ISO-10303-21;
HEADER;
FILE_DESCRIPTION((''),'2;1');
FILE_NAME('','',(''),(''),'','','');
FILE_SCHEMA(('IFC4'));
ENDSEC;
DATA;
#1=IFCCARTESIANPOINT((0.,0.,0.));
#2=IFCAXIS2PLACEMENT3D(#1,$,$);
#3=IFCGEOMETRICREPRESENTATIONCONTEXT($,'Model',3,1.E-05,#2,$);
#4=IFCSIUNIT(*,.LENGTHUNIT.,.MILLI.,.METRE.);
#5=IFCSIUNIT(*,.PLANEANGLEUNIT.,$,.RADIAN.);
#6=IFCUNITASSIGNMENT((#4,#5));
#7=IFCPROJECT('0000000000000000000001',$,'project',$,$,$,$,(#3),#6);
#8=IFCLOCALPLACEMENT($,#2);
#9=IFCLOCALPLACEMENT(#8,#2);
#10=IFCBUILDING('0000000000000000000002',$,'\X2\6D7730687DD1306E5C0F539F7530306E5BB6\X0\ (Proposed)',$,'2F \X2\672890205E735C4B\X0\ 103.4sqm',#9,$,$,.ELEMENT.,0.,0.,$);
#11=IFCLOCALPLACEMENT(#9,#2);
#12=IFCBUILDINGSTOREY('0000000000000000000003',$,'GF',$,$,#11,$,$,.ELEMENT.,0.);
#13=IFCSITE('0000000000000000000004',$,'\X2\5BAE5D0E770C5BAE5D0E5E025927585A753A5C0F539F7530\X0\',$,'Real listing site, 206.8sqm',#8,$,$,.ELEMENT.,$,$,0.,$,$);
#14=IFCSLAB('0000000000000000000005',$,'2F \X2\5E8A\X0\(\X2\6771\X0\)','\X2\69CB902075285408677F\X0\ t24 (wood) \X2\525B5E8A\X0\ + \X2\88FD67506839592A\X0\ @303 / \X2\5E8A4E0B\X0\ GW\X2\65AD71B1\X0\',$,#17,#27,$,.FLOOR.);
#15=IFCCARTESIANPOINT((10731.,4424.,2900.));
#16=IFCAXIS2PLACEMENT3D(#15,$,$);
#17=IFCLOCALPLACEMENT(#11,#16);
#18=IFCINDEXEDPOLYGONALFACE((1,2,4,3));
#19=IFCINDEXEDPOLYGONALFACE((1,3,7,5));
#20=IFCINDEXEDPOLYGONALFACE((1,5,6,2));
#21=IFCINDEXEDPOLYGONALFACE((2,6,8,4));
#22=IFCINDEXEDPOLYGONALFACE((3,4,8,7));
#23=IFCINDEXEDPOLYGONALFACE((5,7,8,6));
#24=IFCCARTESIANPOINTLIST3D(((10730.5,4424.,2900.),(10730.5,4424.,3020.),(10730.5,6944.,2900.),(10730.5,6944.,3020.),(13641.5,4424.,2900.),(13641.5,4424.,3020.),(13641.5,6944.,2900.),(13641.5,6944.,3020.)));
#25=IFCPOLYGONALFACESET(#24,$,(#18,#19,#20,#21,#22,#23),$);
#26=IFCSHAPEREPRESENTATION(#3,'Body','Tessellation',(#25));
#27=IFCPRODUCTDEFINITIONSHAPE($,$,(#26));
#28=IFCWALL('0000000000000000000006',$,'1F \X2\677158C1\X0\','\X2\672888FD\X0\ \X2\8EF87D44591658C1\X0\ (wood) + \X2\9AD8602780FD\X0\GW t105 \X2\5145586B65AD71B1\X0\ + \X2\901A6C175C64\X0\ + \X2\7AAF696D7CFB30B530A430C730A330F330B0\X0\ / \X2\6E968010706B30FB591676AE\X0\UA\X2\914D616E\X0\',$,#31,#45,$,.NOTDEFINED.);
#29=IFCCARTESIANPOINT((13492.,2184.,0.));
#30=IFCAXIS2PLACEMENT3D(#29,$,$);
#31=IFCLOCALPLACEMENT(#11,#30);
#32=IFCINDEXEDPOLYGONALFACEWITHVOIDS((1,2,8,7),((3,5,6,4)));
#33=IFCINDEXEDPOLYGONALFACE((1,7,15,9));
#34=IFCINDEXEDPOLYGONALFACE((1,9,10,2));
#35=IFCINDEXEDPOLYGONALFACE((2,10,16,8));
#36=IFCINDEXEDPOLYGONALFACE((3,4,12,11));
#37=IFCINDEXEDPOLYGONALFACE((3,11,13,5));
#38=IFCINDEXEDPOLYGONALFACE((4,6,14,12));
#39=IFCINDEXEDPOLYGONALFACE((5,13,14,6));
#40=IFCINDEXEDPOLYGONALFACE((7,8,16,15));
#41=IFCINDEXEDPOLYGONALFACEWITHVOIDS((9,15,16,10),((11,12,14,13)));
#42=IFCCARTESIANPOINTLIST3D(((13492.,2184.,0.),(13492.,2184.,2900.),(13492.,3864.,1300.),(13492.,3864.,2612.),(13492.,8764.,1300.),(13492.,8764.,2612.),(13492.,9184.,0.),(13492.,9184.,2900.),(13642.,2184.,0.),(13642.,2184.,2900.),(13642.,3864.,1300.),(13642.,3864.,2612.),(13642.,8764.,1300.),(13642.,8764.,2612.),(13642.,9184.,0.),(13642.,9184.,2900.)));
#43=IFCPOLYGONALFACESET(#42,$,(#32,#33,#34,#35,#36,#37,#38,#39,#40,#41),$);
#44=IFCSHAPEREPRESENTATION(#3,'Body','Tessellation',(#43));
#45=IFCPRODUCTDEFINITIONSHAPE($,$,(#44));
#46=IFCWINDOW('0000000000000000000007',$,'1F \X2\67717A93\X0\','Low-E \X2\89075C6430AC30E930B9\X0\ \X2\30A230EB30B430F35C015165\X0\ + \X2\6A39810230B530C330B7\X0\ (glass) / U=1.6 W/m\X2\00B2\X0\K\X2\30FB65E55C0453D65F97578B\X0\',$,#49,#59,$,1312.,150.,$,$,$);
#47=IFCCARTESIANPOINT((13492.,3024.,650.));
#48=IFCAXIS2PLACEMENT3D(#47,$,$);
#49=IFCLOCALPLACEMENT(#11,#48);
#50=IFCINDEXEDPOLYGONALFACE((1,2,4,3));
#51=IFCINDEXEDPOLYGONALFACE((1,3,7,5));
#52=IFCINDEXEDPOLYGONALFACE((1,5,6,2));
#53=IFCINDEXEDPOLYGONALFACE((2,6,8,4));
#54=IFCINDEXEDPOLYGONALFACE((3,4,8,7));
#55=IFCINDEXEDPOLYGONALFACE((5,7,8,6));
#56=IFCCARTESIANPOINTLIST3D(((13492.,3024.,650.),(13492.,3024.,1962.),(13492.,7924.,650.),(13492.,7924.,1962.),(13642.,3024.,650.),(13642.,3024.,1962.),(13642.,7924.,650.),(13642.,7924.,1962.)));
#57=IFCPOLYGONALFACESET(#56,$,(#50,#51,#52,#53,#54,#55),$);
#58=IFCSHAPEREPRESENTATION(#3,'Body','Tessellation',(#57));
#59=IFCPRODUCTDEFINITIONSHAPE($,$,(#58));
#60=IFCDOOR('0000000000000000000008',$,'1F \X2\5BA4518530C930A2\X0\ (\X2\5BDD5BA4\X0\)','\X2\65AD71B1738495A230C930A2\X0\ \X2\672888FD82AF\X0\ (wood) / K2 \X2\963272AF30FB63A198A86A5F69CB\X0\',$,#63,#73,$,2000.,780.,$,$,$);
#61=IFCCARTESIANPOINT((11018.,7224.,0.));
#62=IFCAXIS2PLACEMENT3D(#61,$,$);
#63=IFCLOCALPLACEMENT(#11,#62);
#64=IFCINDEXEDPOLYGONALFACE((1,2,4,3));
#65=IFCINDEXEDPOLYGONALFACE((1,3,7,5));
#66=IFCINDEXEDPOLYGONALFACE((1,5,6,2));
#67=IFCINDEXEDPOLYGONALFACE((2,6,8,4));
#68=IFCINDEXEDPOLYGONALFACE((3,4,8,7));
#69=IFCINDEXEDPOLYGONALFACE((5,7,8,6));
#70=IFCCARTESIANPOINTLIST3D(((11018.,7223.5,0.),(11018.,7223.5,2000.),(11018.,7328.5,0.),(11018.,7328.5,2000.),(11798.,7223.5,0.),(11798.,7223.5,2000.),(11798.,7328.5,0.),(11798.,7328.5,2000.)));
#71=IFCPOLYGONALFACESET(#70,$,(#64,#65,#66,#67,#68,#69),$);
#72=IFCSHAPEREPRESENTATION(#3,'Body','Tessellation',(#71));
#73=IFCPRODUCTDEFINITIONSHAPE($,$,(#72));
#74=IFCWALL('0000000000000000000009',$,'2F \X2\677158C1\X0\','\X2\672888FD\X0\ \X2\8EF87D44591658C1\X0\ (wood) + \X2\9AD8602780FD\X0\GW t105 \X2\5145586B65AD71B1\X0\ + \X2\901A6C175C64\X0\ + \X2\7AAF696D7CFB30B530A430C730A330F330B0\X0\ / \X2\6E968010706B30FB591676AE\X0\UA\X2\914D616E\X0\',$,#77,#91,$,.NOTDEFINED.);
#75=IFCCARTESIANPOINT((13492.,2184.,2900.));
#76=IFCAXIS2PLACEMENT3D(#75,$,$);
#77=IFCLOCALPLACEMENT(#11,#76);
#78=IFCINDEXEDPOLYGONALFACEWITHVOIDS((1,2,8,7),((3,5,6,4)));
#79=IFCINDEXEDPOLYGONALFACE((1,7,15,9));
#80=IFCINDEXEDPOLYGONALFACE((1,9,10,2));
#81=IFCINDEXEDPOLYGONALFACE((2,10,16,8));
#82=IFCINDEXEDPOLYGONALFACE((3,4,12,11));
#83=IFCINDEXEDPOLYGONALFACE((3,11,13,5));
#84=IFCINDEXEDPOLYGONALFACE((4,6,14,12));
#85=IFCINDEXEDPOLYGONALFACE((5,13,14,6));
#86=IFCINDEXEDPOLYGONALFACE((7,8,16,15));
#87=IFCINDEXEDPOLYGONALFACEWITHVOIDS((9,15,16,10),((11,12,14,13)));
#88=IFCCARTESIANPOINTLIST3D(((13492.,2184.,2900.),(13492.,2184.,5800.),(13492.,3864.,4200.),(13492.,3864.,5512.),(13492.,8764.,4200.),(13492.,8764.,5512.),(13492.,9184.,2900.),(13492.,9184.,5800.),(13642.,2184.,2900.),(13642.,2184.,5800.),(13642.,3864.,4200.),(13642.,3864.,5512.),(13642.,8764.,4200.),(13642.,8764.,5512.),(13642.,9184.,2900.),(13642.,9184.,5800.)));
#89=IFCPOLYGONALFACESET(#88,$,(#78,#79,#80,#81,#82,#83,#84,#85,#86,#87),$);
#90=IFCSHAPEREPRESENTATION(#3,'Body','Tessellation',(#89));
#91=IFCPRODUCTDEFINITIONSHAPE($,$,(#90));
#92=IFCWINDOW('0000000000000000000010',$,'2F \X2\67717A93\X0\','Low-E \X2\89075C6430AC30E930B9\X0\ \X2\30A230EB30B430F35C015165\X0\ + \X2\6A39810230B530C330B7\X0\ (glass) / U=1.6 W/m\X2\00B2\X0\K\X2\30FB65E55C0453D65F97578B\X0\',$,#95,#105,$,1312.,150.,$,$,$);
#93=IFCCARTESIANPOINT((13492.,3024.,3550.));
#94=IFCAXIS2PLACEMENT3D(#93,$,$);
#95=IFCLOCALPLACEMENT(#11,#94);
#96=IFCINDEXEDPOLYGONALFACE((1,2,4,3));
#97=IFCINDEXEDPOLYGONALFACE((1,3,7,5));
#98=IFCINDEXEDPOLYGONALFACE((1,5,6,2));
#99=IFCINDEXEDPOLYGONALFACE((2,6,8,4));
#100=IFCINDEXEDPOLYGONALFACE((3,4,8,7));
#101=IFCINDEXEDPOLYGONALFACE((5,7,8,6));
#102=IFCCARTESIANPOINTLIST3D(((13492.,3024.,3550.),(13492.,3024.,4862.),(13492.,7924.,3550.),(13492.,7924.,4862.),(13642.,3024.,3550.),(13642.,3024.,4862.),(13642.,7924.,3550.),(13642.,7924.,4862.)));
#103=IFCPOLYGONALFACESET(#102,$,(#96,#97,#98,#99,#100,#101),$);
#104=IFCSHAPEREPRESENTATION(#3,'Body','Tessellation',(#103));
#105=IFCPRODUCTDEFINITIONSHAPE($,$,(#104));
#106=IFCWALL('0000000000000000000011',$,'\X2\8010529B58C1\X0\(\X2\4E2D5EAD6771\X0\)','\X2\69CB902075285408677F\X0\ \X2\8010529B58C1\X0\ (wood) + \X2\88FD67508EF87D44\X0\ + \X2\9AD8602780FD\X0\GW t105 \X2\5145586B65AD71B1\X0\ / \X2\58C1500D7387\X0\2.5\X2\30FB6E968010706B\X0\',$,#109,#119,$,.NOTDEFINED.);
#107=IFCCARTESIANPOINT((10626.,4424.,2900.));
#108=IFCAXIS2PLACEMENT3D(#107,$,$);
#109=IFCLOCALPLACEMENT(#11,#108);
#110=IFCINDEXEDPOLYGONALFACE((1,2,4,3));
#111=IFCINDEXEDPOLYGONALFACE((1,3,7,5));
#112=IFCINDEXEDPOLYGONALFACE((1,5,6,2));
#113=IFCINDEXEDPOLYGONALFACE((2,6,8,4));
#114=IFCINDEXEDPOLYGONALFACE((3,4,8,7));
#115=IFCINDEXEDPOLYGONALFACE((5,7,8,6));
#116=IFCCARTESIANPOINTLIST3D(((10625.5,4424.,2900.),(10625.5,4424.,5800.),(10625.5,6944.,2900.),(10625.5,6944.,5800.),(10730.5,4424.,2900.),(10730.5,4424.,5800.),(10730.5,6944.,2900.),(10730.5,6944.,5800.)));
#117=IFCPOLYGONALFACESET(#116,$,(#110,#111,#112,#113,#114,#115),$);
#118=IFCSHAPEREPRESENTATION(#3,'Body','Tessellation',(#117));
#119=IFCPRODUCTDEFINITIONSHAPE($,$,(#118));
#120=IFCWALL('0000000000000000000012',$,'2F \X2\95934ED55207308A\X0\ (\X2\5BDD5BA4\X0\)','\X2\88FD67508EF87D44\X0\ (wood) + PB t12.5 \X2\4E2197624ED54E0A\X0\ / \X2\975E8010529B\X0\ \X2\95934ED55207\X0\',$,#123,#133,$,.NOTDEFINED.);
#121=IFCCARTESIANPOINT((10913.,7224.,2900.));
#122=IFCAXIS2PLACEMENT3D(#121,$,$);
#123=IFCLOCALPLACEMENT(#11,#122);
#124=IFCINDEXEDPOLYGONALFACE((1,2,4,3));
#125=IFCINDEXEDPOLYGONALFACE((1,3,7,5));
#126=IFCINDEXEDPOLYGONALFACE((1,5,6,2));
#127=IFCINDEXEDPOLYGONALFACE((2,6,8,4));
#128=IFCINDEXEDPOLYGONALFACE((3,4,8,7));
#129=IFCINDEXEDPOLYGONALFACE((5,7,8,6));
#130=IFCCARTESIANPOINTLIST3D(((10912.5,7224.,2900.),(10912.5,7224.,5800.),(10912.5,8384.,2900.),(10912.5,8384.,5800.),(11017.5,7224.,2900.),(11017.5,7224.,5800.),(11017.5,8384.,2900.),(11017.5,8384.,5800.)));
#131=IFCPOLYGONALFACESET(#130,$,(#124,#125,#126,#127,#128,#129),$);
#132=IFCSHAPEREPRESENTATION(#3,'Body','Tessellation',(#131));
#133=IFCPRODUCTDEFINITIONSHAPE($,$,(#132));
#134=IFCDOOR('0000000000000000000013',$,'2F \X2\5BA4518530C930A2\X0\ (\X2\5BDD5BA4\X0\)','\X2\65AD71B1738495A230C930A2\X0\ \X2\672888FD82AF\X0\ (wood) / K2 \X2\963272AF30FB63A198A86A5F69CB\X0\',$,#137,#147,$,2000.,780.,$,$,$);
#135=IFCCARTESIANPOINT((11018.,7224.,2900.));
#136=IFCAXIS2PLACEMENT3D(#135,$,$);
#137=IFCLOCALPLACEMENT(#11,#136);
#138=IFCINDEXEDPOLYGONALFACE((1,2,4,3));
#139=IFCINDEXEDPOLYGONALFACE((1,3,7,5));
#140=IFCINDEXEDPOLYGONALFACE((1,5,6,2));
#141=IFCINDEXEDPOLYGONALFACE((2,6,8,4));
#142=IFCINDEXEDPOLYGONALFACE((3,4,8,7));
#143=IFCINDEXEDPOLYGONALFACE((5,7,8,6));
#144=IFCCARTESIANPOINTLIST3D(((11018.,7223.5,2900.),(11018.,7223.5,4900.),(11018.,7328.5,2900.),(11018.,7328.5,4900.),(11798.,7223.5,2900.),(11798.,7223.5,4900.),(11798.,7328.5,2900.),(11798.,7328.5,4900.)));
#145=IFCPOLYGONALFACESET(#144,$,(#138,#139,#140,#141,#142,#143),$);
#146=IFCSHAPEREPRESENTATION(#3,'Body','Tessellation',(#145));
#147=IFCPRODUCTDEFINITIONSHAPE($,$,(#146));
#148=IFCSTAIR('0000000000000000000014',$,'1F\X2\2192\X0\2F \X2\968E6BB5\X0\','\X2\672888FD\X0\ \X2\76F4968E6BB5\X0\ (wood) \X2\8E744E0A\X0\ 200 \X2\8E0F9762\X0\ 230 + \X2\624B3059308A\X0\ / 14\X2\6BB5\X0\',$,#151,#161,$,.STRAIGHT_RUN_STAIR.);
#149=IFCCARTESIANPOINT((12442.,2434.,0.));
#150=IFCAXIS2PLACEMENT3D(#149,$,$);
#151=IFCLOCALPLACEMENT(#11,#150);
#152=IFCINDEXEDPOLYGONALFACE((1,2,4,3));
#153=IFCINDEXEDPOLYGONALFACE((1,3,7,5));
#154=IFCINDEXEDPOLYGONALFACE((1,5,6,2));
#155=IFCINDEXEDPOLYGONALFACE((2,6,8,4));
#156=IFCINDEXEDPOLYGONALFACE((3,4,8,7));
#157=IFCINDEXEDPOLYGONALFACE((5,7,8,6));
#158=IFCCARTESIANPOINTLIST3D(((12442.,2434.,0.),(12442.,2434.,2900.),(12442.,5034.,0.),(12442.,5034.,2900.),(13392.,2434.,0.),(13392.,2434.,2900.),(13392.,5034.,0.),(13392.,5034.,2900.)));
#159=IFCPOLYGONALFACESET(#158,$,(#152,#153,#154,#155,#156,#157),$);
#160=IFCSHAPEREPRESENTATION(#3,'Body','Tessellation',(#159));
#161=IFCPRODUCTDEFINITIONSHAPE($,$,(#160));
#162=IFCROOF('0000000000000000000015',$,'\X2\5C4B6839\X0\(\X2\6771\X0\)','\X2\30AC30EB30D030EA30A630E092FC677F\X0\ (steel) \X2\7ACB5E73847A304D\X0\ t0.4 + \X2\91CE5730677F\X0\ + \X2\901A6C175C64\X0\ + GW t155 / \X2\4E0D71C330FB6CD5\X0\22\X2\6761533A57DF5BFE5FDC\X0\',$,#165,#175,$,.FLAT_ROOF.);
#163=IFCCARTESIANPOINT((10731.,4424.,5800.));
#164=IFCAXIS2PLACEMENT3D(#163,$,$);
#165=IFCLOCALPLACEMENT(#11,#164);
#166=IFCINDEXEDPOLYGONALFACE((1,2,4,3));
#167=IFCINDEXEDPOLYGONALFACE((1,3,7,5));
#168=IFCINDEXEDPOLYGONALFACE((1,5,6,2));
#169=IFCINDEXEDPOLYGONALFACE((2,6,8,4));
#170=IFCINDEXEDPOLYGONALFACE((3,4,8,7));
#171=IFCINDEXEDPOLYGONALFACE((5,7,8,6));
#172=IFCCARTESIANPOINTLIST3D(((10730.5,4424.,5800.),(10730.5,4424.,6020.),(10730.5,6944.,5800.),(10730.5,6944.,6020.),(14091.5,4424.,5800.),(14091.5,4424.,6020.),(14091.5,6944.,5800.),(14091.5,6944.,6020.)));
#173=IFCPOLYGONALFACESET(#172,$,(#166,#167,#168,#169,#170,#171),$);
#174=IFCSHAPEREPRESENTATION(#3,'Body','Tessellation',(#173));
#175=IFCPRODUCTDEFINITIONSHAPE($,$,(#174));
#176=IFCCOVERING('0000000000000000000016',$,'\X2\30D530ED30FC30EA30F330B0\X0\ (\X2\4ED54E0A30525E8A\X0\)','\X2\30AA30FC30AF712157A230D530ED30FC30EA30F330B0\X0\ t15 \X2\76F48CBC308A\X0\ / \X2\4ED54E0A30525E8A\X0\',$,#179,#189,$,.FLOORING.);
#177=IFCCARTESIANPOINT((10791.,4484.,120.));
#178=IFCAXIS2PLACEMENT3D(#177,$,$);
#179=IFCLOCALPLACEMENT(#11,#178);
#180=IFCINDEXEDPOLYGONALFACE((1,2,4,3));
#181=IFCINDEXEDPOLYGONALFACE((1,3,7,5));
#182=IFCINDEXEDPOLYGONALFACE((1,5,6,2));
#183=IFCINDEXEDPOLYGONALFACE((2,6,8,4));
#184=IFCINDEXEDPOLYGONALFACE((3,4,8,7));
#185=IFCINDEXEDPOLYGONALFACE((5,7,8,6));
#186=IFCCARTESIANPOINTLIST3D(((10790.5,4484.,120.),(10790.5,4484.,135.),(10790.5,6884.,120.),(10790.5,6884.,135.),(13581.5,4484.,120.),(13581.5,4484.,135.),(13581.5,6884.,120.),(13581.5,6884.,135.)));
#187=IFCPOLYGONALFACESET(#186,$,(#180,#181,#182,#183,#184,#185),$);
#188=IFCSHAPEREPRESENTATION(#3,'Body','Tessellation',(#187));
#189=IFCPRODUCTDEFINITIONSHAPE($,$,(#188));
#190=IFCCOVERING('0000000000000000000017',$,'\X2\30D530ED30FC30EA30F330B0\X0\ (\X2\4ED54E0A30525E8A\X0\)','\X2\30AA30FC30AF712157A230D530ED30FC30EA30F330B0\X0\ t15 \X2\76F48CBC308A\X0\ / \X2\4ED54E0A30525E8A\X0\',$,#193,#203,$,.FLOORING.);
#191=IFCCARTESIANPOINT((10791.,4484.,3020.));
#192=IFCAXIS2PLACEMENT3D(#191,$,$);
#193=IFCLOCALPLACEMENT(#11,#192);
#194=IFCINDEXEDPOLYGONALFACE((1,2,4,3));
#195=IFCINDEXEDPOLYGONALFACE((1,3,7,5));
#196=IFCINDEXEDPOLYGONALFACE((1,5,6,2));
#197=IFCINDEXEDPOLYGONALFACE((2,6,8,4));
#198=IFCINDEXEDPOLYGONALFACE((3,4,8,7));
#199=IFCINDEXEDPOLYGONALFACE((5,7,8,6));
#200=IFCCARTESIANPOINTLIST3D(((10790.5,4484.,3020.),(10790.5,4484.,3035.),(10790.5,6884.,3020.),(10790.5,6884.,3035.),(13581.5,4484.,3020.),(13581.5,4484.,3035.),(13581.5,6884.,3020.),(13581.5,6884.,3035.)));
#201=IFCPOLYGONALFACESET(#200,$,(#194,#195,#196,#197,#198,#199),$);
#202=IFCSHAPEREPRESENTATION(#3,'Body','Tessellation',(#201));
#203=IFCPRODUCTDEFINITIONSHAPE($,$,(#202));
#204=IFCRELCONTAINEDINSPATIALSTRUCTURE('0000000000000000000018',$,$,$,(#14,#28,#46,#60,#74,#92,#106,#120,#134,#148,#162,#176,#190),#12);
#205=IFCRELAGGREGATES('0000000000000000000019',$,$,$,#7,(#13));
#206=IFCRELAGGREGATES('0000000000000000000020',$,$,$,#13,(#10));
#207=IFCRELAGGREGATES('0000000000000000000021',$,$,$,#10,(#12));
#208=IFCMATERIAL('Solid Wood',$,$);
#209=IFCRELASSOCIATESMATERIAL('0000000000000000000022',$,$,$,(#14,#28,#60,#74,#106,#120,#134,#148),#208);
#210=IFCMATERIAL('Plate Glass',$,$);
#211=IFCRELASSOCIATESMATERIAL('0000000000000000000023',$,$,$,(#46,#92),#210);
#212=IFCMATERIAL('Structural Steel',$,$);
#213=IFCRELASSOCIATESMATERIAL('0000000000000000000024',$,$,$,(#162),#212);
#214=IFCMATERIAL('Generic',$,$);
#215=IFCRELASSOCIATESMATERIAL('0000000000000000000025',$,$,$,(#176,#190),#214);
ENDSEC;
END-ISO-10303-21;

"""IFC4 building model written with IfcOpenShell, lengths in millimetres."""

from ifc_helpers import new_model, si_unit, frame, frame_2d, origin, place, context, project, spatial, rectangle, extrude, material, element, fill, save


model = new_model("IFC4")

# Units and contexts
model_context = context("Model", 3, precision=1e-05, world=origin())
ifc_project = project(units=[si_unit("LENGTHUNIT", "METRE", prefix="MILLI"), si_unit("PLANEANGLEUNIT", "RADIAN")], contexts=[model_context])

# Site, building, storey
site_placement = place(None, origin())
site = spatial("IfcSite", under=ifc_project, at=site_placement, Name="宮崎県宮崎市大塚町小原田", ObjectType="Real listing site, 206.8sqm", CompositionType="ELEMENT", RefElevation=0.0)
building_placement = place(site_placement, origin())
building = spatial("IfcBuilding", under=site, at=building_placement, Name="海と緑の小原田の家 (Proposed)", ObjectType="2F 木造平屋 103.4sqm", CompositionType="ELEMENT", ElevationOfRefHeight=0.0, ElevationOfTerrain=0.0)
storey_placement = place(building_placement, origin())
storey = spatial("IfcBuildingStorey", under=building, at=storey_placement, Name="GF", CompositionType="ELEMENT", Elevation=0.0)

# Slab
ifc_material_1 = material(Name="Solid Wood")
slab_1_placement = place(storey_placement, frame((10731.0, 4424.0, 2900.0)))
element("IfcSlab", 1, at=slab_1_placement, inside=storey, material=ifc_material_1, Name="2F 床(東)", Description="構造用合板 t24 (wood) 剛床 + 製材根太 @303 / 床下 GW断熱", PredefinedType="FLOOR", context=model_context, shape_type="SweptSolid", body=[
    extrude(rectangle(XDim=2911.0, YDim=2520.0, at=frame_2d((1455.0, 1260.0))), frame((10731.0, 4424.0, 2900.0)), (0.0, 0.0, 1.0), 120.0),
])

# Wall, opening, window
wall_1_placement = place(storey_placement, frame((13492.0, 2184.0, 0.0)))
wall_1 = element("IfcWall", 2, at=wall_1_placement, inside=storey, material=ifc_material_1, Name="1F 東壁", Description="木製 軸組外壁 (wood) + 高性能GW t105 充填断熱 + 通気層 + 窯業系サイディング / 準耐火・外皮UA配慮", PredefinedType="NOTDEFINED", context=model_context, shape_type="SweptSolid", body=[
    extrude(rectangle(XDim=150.0, YDim=7000.0, at=frame_2d((75.0, 3500.0))), frame((13492.0, 2184.0, 0.0)), (0.0, 0.0, 1.0), 2900.0),
])
opening_1_placement = place(storey_placement, frame((13492.0, 3024.0, 650.0)))
opening_1 = element("IfcOpeningElement", 3, at=opening_1_placement, cuts=wall_1, PredefinedType="NOTDEFINED", context=model_context, shape_type="SweptSolid", body=[
    extrude(rectangle(XDim=150.0, YDim=4900.0, at=frame_2d((75.0, 2450.0))), frame((13492.0, 3024.0, 650.0)), (0.0, 0.0, 1.0), 1312.0),
])
ifc_material_2 = material(Name="Plate Glass")
window_1_placement = place(storey_placement, frame((13492.0, 3024.0, 650.0)))
window_1 = element("IfcWindow", 4, at=window_1_placement, inside=storey, material=ifc_material_2, Name="1F 東窓", Description="Low-E 複層ガラス アルゴン封入 + 樹脂サッシ (glass) / U=1.6 W/m²K・日射取得型", OverallHeight=1312.0, OverallWidth=150.0, context=model_context, shape_type="SweptSolid", body=[
    extrude(rectangle(XDim=150.0, YDim=4900.0, at=frame_2d((75.0, 2450.0))), frame((13492.0, 3024.0, 650.0)), (0.0, 0.0, 1.0), 1312.0),
])
fill(opening_1, window_1)

# Door
door_1_placement = place(storey_placement, frame((11018.0, 7224.0, 0.0)))
element("IfcDoor", 5, at=door_1_placement, inside=storey, material=ifc_material_1, Name="1F 室内ドア (寝室)", Description="断熱玄関ドア 木製芯 (wood) / K2 防犯・採風機構", OverallHeight=2000.0, OverallWidth=780.0, context=model_context, shape_type="SweptSolid", body=[
    extrude(rectangle(XDim=780.0, YDim=105.0, at=frame_2d((390.0, 52.0))), frame((11018.0, 7224.0, 0.0)), (0.0, 0.0, 1.0), 2000.0),
])

# Wall, opening, window
wall_2_placement = place(storey_placement, frame((13492.0, 2184.0, 2900.0)))
wall_2 = element("IfcWall", 6, at=wall_2_placement, inside=storey, material=ifc_material_1, Name="2F 東壁", Description="木製 軸組外壁 (wood) + 高性能GW t105 充填断熱 + 通気層 + 窯業系サイディング / 準耐火・外皮UA配慮", PredefinedType="NOTDEFINED", context=model_context, shape_type="SweptSolid", body=[
    extrude(rectangle(XDim=150.0, YDim=7000.0, at=frame_2d((75.0, 3500.0))), frame((13492.0, 2184.0, 2900.0)), (0.0, 0.0, 1.0), 2900.0),
])
opening_2_placement = place(storey_placement, frame((13492.0, 3024.0, 3550.0)))
opening_2 = element("IfcOpeningElement", 7, at=opening_2_placement, cuts=wall_2, PredefinedType="NOTDEFINED", context=model_context, shape_type="SweptSolid", body=[
    extrude(rectangle(XDim=150.0, YDim=4900.0, at=frame_2d((75.0, 2450.0))), frame((13492.0, 3024.0, 3550.0)), (0.0, 0.0, 1.0), 1312.0),
])
window_2_placement = place(storey_placement, frame((13492.0, 3024.0, 3550.0)))
window_2 = element("IfcWindow", 8, at=window_2_placement, inside=storey, material=ifc_material_2, Name="2F 東窓", Description="Low-E 複層ガラス アルゴン封入 + 樹脂サッシ (glass) / U=1.6 W/m²K・日射取得型", OverallHeight=1312.0, OverallWidth=150.0, context=model_context, shape_type="SweptSolid", body=[
    extrude(rectangle(XDim=150.0, YDim=4900.0, at=frame_2d((75.0, 2450.0))), frame((13492.0, 3024.0, 3550.0)), (0.0, 0.0, 1.0), 1312.0),
])
fill(opening_2, window_2)

# Walls
wall_3_placement = place(storey_placement, frame((10626.0, 4424.0, 2900.0)))
element("IfcWall", 9, at=wall_3_placement, inside=storey, material=ifc_material_1, Name="耐力壁(中庭東)", Description="構造用合板 耐力壁 (wood) + 製材軸組 + 高性能GW t105 充填断熱 / 壁倍率2.5・準耐火", PredefinedType="NOTDEFINED", context=model_context, shape_type="SweptSolid", body=[
    extrude(rectangle(XDim=105.0, YDim=2520.0, at=frame_2d((52.0, 1260.0))), frame((10626.0, 4424.0, 2900.0)), (0.0, 0.0, 1.0), 2900.0),
])
wall_4_placement = place(storey_placement, frame((10913.0, 7224.0, 2900.0)))
element("IfcWall", 10, at=wall_4_placement, inside=storey, material=ifc_material_1, Name="2F 間仕切り (寝室)", Description="製材軸組 (wood) + PB t12.5 両面仕上 / 非耐力 間仕切", PredefinedType="NOTDEFINED", context=model_context, shape_type="SweptSolid", body=[
    extrude(rectangle(XDim=105.0, YDim=1160.0, at=frame_2d((52.0, 580.0))), frame((10913.0, 7224.0, 2900.0)), (0.0, 0.0, 1.0), 2900.0),
])

# Door
door_2_placement = place(storey_placement, frame((11018.0, 7224.0, 2900.0)))
element("IfcDoor", 11, at=door_2_placement, inside=storey, material=ifc_material_1, Name="2F 室内ドア (寝室)", Description="断熱玄関ドア 木製芯 (wood) / K2 防犯・採風機構", OverallHeight=2000.0, OverallWidth=780.0, context=model_context, shape_type="SweptSolid", body=[
    extrude(rectangle(XDim=780.0, YDim=105.0, at=frame_2d((390.0, 52.0))), frame((11018.0, 7224.0, 2900.0)), (0.0, 0.0, 1.0), 2000.0),
])

# Stair
stair_placement = place(storey_placement, frame((12442.0, 2434.0, 0.0)))
element("IfcStair", 12, at=stair_placement, inside=storey, material=ifc_material_1, Name="1F→2F 階段", Description="木製 直階段 (wood) 蹴上 200 踏面 230 + 手すり / 14段", PredefinedType="STRAIGHT_RUN_STAIR", context=model_context, shape_type="SweptSolid", body=[
    extrude(rectangle(XDim=950.0, YDim=2600.0, at=frame_2d((475.0, 1300.0))), frame((12442.0, 2434.0, 0.0)), (0.0, 0.0, 1.0), 2900.0),
])

# Roof
ifc_material_3 = material(Name="Structural Steel")
for number, where, name in (
    (13, (10731.0, 4424.0, 5800.0), "屋根(東)"),
):
    element("IfcRoof", number, at=place(storey_placement, frame(where)), inside=storey, material=ifc_material_3, Name=name, Description="ガルバリウム鋼板 (steel) 立平葺き t0.4 + 野地板 + 通気層 + GW t155 / 不燃・法22条区域対応", PredefinedType="FLAT_ROOF", context=model_context, shape_type="SweptSolid", body=[
        extrude(rectangle(XDim=3361.0, YDim=2520.0, at=frame_2d((1680.0, 1260.0))), frame((10731.0, 4424.0, 5800.0)), (0.0, 0.0, 1.0), 220.0),
    ])

# Coverings
ifc_material_4 = material(Name="Generic")
covering_1_placement = place(storey_placement, frame((10791.0, 4484.0, 120.0)))
element("IfcCovering", 14, at=covering_1_placement, inside=storey, material=ifc_material_4, Name="フローリング (仕上げ床)", Description="オーク無垢フローリング t15 直貼り / 仕上げ床", PredefinedType="FLOORING", context=model_context, shape_type="SweptSolid", body=[
    extrude(rectangle(XDim=2791.0, YDim=2400.0, at=frame_2d((1395.0, 1200.0))), frame((10791.0, 4484.0, 120.0)), (0.0, 0.0, 1.0), 15.0),
])
covering_2_placement = place(storey_placement, frame((10791.0, 4484.0, 3020.0)))
element("IfcCovering", 15, at=covering_2_placement, inside=storey, material=ifc_material_4, Name="フローリング (仕上げ床)", Description="オーク無垢フローリング t15 直貼り / 仕上げ床", PredefinedType="FLOORING", context=model_context, shape_type="SweptSolid", body=[
    extrude(rectangle(XDim=2791.0, YDim=2400.0, at=frame_2d((1395.0, 1200.0))), frame((10791.0, 4484.0, 3020.0)), (0.0, 0.0, 1.0), 15.0),
])

save(model, "model.ifc")
